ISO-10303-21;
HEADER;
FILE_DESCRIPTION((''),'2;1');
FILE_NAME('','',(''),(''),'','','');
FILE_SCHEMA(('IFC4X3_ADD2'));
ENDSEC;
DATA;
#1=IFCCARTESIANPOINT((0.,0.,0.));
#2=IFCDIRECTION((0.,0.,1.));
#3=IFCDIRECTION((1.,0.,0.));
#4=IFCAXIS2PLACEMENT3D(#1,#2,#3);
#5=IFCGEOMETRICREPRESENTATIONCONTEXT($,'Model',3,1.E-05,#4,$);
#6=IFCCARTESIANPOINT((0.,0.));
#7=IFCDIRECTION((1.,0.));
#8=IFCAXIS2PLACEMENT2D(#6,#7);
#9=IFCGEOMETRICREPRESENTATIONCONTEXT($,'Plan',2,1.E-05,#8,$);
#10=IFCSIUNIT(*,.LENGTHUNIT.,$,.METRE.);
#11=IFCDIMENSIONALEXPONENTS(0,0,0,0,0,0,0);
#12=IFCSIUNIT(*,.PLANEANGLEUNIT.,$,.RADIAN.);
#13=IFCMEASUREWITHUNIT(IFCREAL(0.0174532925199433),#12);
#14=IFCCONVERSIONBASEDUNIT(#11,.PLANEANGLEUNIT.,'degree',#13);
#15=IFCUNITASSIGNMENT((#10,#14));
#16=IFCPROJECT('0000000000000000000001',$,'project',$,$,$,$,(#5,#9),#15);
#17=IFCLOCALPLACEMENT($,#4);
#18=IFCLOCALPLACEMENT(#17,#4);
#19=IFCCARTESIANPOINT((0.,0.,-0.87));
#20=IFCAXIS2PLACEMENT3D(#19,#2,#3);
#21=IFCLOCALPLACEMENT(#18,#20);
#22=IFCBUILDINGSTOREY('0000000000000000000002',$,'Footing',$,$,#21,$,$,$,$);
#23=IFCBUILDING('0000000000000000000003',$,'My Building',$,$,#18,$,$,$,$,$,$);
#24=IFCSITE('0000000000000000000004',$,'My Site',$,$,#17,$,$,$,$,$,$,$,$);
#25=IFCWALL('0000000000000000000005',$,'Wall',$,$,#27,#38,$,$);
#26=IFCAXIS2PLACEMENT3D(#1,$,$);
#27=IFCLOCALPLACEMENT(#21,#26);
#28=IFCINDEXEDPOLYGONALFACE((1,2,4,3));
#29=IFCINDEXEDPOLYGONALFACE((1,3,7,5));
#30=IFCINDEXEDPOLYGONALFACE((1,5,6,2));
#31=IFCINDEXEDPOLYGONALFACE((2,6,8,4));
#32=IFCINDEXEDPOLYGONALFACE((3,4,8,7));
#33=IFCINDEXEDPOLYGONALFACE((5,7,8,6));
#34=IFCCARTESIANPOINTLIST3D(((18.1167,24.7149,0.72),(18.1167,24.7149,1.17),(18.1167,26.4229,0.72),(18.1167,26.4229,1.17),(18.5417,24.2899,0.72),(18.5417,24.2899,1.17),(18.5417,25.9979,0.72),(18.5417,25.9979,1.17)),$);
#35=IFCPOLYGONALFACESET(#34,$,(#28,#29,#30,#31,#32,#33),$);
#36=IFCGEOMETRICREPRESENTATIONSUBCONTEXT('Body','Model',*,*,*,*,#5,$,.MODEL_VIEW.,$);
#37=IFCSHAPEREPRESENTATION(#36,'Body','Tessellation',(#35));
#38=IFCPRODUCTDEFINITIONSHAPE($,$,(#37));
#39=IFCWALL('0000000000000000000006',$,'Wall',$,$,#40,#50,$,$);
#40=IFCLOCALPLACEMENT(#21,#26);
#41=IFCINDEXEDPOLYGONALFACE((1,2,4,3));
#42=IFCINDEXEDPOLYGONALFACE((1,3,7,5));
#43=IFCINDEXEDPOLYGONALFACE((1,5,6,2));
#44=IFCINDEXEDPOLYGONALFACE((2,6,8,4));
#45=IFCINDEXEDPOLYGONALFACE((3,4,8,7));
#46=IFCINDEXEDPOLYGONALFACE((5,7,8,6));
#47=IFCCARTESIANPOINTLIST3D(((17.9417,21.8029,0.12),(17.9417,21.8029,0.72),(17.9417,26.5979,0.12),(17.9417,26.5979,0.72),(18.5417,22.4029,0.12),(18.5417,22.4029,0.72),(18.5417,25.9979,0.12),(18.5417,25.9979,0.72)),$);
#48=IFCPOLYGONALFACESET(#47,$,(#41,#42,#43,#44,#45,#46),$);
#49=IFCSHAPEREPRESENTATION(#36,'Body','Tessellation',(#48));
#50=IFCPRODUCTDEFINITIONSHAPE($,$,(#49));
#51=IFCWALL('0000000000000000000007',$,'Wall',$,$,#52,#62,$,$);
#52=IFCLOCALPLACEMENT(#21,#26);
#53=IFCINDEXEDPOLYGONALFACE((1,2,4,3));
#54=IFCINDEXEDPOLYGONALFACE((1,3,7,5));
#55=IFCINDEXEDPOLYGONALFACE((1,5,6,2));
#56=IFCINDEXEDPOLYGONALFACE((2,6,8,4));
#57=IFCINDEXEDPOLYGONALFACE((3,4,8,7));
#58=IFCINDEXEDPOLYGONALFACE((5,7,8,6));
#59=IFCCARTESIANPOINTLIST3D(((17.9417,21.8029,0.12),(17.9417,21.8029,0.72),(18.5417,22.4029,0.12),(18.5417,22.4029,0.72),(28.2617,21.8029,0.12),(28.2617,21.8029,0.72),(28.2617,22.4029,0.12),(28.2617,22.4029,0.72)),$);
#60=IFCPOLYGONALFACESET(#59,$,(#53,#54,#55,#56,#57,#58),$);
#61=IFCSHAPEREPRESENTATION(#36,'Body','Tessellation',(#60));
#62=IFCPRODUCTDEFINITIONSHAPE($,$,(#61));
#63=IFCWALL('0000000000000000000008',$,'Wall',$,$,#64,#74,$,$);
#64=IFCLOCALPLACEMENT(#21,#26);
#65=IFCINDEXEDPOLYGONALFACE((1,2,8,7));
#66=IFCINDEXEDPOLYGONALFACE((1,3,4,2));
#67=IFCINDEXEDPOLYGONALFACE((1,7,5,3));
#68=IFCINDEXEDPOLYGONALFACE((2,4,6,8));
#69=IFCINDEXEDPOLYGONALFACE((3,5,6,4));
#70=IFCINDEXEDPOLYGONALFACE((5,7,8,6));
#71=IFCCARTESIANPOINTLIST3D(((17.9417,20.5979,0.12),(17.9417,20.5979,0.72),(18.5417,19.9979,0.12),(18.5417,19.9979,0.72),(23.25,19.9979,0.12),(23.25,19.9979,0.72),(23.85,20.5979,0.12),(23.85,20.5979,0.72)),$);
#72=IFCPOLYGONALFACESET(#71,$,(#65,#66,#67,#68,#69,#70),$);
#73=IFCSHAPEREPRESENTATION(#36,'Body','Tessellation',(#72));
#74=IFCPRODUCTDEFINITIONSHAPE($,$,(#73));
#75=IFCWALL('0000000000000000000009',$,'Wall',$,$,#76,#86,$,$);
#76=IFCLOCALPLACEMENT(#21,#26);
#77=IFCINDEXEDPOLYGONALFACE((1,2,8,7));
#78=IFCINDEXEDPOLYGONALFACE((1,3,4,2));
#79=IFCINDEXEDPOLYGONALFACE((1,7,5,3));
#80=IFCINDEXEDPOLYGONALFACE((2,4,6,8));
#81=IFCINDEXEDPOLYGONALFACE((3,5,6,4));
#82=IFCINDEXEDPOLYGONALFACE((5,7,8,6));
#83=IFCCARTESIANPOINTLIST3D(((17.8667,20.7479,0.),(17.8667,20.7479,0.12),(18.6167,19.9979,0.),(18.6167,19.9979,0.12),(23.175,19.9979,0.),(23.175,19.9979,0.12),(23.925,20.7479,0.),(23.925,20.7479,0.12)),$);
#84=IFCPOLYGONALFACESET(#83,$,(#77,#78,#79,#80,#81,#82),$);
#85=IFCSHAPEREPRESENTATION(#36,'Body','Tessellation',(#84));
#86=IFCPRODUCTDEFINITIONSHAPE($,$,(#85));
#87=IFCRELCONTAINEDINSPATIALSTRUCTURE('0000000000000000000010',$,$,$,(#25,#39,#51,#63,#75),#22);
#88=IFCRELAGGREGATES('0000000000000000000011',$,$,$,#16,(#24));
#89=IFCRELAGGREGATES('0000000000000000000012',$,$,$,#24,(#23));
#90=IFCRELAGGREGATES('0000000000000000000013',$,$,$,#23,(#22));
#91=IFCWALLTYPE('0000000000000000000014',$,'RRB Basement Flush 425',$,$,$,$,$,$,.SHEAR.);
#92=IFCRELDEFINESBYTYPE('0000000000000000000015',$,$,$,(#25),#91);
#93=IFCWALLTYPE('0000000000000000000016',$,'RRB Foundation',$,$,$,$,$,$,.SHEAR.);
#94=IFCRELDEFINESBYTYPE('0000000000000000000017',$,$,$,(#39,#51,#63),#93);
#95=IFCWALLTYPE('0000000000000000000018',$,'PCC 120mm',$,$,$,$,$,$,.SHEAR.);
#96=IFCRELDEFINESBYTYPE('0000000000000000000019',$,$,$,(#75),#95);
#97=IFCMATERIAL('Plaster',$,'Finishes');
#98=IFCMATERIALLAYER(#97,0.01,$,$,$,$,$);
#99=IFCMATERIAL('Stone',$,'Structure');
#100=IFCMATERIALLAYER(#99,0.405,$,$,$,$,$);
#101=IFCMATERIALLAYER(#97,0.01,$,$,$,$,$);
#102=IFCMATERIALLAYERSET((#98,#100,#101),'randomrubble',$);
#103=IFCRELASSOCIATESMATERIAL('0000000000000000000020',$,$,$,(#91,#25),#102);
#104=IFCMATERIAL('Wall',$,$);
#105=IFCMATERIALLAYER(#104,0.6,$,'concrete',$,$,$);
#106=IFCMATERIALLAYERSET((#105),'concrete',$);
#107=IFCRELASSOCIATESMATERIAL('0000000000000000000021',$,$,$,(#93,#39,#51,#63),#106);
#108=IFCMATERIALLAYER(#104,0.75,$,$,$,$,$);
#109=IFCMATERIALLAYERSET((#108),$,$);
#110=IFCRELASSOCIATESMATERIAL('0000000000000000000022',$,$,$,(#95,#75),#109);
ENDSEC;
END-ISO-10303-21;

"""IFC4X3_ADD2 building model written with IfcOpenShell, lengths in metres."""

from ifc_helpers import new_model, entity, si_unit, converted_unit, frame, origin_with_axes, origin_2d_with_axis, place, context, subcontext, project, spatial, line, indexed_curve, outline, extrude, material, layer, layer_set, layer_usage, type_object, element, save


model = new_model("IFC4X3_ADD2")

# Units and contexts
model_context = context("Model", 3, precision=1e-05, world=origin_with_axes())
plan_context = context("Plan", 2, precision=1e-05, world=origin_2d_with_axis())
body_context = subcontext(model_context, "Body", "Model", "MODEL_VIEW")
ifc_project = project(units=[si_unit("LENGTHUNIT", "METRE"), converted_unit("PLANEANGLEUNIT", "degree", entity("IfcReal", 0.0174532925199433), si_unit("PLANEANGLEUNIT", "RADIAN"), dimensions=[0, 0, 0, 0, 0, 0, 0])], contexts=[model_context, plan_context])

# Site, building, storey
site_placement = place(None, origin_with_axes())
site = spatial("IfcSite", under=ifc_project, at=site_placement, Name="My Site")
building_placement = place(site_placement, origin_with_axes())
building = spatial("IfcBuilding", under=site, at=building_placement, Name="My Building")
storey_placement = place(building_placement, frame((0.0, 0.0, -0.87), z_axis=(0.0, 0.0, 1.0), x_axis=(1.0, 0.0, 0.0)))
storey = spatial("IfcBuildingStorey", under=building, at=storey_placement, Name="Footing")

# Shared definitions
ifc_material_1 = material(Name="Stone", Category="Structure")

# Walls
ifc_material_2 = material(Name="Plaster", Category="Finishes")
ifc_layer_1 = layer(ifc_material_2, 0.01)
ifc_layer_2 = layer(ifc_material_1, 0.405)
ifc_layer_3 = layer(ifc_material_2, 0.01)
ifc_layer_set_1 = layer_set([ifc_layer_1, ifc_layer_2, ifc_layer_3], Name="randomrubble")
wall_type_1 = type_object("IfcWallType", Name="RRB Basement Flush 425", PredefinedType="SHEAR", material=ifc_layer_set_1)
ifc_layer_usage_1 = layer_usage(ifc_layer_set_1, "AXIS2", "POSITIVE", 0.0)
wall_1_placement = place(storey_placement, frame((18.5417, 24.7149, 0.72), z_axis=(0.0, 0.0, 1.0), x_axis=(0.0, 1.0, 0.0)))
element("IfcWall", 1, at=wall_1_placement, inside=storey, type_object=wall_type_1, material=ifc_layer_usage_1, Name="Wall", context=body_context, shape_type="SweptSolid", body=[
    extrude(outline(indexed_curve([(-0.425, 0.0), (0.0, 0.425), (1.708, 0.425), (1.283, 0.0)], segments=[line(1, 2, 3, 4, 1)])), origin_with_axes(), (0.0, 0.0, 1.0), 0.45),
])
ifc_material_3 = material(Name="Wall")
ifc_layer_4 = layer(ifc_material_3, 0.6, Name="concrete")
ifc_layer_set_2 = layer_set([ifc_layer_4], Name="concrete")
ifc_layer_usage_2 = layer_usage(ifc_layer_set_2, "AXIS2", "POSITIVE", 0.0)
wall_type_2 = type_object("IfcWallType", Name="RRB Foundation", PredefinedType="SHEAR", material=ifc_layer_set_2)
wall_2_placement = place(storey_placement, frame((18.5417, 21.8029, 0.12), z_axis=(0.0, 0.0, 1.0), x_axis=(0.0, 1.0, 0.0)))
element("IfcWall", 2, at=wall_2_placement, inside=storey, type_object=wall_type_2, material=ifc_layer_usage_2, Name="Wall", context=body_context, shape_type="SweptSolid", body=[
    extrude(outline(indexed_curve([(0.6, 0.0), (0.0, 0.6), (4.795, 0.6), (4.195, 0.0)], segments=[line(1, 2, 3, 4, 1)])), origin_with_axes(), (0.0, 0.0, 1.0), 0.6),
])
ifc_layer_usage_3 = layer_usage(ifc_layer_set_2, "AXIS2", "POSITIVE", 0.0)
wall_3_placement = place(storey_placement, frame((18.5417, 21.8029, 0.12), z_axis=(0.0, 0.0, 1.0), x_axis=(1.0, -0.000001, 0.0)))
element("IfcWall", 3, at=wall_3_placement, inside=storey, type_object=wall_type_2, material=ifc_layer_usage_3, Name="Wall", context=body_context, shape_type="SweptSolid", body=[
    extrude(outline(indexed_curve([(-0.6, 0.0), (0.0, 0.6), (9.72, 0.6), (9.72, 0.0)], segments=[line(1, 2, 3, 4, 1)])), origin_with_axes(), (0.0, 0.0, 1.0), 0.6),
])
ifc_layer_usage_4 = layer_usage(ifc_layer_set_2, "AXIS2", "POSITIVE", 0.0)
wall_4_placement = place(storey_placement, frame((18.5417, 19.9979, 0.12), z_axis=(0.0, 0.0, 1.0), x_axis=(1.0, -0.000001, 0.0)))
element("IfcWall", 4, at=wall_4_placement, inside=storey, type_object=wall_type_2, material=ifc_layer_usage_4, Name="Wall", context=body_context, shape_type="SweptSolid", body=[
    extrude(outline(indexed_curve([(0.0, 0.0), (-0.6, 0.6), (5.3083, 0.6), (4.7083, 0.0)], segments=[line(1, 2, 3, 4, 1)])), origin_with_axes(), (0.0, 0.0, 1.0), 0.6),
])
ifc_layer_5 = layer(ifc_material_3, 0.75)
ifc_layer_set_3 = layer_set([ifc_layer_5])
wall_type_3 = type_object("IfcWallType", Name="PCC 120mm", PredefinedType="SHEAR", material=ifc_layer_set_3)
ifc_layer_usage_5 = layer_usage(ifc_layer_set_3, "AXIS2", "POSITIVE", 0.0)
wall_5_placement = place(storey_placement, frame((18.6167, 19.9979, 0.0), z_axis=(0.0, 0.0, 1.0), x_axis=(1.0, -0.000001, 0.0)))
element("IfcWall", 5, at=wall_5_placement, inside=storey, type_object=wall_type_3, material=ifc_layer_usage_5, Name="Wall", context=body_context, shape_type="SweptSolid", body=[
    extrude(outline(indexed_curve([(0.0, 0.0), (-0.75, 0.75), (5.3083, 0.75), (4.5583, 0.0)], segments=[line(1, 2, 3, 4, 1)])), origin_with_axes(), (0.0, 0.0, 1.0), 0.12),
])

save(model, "model.ifc")
